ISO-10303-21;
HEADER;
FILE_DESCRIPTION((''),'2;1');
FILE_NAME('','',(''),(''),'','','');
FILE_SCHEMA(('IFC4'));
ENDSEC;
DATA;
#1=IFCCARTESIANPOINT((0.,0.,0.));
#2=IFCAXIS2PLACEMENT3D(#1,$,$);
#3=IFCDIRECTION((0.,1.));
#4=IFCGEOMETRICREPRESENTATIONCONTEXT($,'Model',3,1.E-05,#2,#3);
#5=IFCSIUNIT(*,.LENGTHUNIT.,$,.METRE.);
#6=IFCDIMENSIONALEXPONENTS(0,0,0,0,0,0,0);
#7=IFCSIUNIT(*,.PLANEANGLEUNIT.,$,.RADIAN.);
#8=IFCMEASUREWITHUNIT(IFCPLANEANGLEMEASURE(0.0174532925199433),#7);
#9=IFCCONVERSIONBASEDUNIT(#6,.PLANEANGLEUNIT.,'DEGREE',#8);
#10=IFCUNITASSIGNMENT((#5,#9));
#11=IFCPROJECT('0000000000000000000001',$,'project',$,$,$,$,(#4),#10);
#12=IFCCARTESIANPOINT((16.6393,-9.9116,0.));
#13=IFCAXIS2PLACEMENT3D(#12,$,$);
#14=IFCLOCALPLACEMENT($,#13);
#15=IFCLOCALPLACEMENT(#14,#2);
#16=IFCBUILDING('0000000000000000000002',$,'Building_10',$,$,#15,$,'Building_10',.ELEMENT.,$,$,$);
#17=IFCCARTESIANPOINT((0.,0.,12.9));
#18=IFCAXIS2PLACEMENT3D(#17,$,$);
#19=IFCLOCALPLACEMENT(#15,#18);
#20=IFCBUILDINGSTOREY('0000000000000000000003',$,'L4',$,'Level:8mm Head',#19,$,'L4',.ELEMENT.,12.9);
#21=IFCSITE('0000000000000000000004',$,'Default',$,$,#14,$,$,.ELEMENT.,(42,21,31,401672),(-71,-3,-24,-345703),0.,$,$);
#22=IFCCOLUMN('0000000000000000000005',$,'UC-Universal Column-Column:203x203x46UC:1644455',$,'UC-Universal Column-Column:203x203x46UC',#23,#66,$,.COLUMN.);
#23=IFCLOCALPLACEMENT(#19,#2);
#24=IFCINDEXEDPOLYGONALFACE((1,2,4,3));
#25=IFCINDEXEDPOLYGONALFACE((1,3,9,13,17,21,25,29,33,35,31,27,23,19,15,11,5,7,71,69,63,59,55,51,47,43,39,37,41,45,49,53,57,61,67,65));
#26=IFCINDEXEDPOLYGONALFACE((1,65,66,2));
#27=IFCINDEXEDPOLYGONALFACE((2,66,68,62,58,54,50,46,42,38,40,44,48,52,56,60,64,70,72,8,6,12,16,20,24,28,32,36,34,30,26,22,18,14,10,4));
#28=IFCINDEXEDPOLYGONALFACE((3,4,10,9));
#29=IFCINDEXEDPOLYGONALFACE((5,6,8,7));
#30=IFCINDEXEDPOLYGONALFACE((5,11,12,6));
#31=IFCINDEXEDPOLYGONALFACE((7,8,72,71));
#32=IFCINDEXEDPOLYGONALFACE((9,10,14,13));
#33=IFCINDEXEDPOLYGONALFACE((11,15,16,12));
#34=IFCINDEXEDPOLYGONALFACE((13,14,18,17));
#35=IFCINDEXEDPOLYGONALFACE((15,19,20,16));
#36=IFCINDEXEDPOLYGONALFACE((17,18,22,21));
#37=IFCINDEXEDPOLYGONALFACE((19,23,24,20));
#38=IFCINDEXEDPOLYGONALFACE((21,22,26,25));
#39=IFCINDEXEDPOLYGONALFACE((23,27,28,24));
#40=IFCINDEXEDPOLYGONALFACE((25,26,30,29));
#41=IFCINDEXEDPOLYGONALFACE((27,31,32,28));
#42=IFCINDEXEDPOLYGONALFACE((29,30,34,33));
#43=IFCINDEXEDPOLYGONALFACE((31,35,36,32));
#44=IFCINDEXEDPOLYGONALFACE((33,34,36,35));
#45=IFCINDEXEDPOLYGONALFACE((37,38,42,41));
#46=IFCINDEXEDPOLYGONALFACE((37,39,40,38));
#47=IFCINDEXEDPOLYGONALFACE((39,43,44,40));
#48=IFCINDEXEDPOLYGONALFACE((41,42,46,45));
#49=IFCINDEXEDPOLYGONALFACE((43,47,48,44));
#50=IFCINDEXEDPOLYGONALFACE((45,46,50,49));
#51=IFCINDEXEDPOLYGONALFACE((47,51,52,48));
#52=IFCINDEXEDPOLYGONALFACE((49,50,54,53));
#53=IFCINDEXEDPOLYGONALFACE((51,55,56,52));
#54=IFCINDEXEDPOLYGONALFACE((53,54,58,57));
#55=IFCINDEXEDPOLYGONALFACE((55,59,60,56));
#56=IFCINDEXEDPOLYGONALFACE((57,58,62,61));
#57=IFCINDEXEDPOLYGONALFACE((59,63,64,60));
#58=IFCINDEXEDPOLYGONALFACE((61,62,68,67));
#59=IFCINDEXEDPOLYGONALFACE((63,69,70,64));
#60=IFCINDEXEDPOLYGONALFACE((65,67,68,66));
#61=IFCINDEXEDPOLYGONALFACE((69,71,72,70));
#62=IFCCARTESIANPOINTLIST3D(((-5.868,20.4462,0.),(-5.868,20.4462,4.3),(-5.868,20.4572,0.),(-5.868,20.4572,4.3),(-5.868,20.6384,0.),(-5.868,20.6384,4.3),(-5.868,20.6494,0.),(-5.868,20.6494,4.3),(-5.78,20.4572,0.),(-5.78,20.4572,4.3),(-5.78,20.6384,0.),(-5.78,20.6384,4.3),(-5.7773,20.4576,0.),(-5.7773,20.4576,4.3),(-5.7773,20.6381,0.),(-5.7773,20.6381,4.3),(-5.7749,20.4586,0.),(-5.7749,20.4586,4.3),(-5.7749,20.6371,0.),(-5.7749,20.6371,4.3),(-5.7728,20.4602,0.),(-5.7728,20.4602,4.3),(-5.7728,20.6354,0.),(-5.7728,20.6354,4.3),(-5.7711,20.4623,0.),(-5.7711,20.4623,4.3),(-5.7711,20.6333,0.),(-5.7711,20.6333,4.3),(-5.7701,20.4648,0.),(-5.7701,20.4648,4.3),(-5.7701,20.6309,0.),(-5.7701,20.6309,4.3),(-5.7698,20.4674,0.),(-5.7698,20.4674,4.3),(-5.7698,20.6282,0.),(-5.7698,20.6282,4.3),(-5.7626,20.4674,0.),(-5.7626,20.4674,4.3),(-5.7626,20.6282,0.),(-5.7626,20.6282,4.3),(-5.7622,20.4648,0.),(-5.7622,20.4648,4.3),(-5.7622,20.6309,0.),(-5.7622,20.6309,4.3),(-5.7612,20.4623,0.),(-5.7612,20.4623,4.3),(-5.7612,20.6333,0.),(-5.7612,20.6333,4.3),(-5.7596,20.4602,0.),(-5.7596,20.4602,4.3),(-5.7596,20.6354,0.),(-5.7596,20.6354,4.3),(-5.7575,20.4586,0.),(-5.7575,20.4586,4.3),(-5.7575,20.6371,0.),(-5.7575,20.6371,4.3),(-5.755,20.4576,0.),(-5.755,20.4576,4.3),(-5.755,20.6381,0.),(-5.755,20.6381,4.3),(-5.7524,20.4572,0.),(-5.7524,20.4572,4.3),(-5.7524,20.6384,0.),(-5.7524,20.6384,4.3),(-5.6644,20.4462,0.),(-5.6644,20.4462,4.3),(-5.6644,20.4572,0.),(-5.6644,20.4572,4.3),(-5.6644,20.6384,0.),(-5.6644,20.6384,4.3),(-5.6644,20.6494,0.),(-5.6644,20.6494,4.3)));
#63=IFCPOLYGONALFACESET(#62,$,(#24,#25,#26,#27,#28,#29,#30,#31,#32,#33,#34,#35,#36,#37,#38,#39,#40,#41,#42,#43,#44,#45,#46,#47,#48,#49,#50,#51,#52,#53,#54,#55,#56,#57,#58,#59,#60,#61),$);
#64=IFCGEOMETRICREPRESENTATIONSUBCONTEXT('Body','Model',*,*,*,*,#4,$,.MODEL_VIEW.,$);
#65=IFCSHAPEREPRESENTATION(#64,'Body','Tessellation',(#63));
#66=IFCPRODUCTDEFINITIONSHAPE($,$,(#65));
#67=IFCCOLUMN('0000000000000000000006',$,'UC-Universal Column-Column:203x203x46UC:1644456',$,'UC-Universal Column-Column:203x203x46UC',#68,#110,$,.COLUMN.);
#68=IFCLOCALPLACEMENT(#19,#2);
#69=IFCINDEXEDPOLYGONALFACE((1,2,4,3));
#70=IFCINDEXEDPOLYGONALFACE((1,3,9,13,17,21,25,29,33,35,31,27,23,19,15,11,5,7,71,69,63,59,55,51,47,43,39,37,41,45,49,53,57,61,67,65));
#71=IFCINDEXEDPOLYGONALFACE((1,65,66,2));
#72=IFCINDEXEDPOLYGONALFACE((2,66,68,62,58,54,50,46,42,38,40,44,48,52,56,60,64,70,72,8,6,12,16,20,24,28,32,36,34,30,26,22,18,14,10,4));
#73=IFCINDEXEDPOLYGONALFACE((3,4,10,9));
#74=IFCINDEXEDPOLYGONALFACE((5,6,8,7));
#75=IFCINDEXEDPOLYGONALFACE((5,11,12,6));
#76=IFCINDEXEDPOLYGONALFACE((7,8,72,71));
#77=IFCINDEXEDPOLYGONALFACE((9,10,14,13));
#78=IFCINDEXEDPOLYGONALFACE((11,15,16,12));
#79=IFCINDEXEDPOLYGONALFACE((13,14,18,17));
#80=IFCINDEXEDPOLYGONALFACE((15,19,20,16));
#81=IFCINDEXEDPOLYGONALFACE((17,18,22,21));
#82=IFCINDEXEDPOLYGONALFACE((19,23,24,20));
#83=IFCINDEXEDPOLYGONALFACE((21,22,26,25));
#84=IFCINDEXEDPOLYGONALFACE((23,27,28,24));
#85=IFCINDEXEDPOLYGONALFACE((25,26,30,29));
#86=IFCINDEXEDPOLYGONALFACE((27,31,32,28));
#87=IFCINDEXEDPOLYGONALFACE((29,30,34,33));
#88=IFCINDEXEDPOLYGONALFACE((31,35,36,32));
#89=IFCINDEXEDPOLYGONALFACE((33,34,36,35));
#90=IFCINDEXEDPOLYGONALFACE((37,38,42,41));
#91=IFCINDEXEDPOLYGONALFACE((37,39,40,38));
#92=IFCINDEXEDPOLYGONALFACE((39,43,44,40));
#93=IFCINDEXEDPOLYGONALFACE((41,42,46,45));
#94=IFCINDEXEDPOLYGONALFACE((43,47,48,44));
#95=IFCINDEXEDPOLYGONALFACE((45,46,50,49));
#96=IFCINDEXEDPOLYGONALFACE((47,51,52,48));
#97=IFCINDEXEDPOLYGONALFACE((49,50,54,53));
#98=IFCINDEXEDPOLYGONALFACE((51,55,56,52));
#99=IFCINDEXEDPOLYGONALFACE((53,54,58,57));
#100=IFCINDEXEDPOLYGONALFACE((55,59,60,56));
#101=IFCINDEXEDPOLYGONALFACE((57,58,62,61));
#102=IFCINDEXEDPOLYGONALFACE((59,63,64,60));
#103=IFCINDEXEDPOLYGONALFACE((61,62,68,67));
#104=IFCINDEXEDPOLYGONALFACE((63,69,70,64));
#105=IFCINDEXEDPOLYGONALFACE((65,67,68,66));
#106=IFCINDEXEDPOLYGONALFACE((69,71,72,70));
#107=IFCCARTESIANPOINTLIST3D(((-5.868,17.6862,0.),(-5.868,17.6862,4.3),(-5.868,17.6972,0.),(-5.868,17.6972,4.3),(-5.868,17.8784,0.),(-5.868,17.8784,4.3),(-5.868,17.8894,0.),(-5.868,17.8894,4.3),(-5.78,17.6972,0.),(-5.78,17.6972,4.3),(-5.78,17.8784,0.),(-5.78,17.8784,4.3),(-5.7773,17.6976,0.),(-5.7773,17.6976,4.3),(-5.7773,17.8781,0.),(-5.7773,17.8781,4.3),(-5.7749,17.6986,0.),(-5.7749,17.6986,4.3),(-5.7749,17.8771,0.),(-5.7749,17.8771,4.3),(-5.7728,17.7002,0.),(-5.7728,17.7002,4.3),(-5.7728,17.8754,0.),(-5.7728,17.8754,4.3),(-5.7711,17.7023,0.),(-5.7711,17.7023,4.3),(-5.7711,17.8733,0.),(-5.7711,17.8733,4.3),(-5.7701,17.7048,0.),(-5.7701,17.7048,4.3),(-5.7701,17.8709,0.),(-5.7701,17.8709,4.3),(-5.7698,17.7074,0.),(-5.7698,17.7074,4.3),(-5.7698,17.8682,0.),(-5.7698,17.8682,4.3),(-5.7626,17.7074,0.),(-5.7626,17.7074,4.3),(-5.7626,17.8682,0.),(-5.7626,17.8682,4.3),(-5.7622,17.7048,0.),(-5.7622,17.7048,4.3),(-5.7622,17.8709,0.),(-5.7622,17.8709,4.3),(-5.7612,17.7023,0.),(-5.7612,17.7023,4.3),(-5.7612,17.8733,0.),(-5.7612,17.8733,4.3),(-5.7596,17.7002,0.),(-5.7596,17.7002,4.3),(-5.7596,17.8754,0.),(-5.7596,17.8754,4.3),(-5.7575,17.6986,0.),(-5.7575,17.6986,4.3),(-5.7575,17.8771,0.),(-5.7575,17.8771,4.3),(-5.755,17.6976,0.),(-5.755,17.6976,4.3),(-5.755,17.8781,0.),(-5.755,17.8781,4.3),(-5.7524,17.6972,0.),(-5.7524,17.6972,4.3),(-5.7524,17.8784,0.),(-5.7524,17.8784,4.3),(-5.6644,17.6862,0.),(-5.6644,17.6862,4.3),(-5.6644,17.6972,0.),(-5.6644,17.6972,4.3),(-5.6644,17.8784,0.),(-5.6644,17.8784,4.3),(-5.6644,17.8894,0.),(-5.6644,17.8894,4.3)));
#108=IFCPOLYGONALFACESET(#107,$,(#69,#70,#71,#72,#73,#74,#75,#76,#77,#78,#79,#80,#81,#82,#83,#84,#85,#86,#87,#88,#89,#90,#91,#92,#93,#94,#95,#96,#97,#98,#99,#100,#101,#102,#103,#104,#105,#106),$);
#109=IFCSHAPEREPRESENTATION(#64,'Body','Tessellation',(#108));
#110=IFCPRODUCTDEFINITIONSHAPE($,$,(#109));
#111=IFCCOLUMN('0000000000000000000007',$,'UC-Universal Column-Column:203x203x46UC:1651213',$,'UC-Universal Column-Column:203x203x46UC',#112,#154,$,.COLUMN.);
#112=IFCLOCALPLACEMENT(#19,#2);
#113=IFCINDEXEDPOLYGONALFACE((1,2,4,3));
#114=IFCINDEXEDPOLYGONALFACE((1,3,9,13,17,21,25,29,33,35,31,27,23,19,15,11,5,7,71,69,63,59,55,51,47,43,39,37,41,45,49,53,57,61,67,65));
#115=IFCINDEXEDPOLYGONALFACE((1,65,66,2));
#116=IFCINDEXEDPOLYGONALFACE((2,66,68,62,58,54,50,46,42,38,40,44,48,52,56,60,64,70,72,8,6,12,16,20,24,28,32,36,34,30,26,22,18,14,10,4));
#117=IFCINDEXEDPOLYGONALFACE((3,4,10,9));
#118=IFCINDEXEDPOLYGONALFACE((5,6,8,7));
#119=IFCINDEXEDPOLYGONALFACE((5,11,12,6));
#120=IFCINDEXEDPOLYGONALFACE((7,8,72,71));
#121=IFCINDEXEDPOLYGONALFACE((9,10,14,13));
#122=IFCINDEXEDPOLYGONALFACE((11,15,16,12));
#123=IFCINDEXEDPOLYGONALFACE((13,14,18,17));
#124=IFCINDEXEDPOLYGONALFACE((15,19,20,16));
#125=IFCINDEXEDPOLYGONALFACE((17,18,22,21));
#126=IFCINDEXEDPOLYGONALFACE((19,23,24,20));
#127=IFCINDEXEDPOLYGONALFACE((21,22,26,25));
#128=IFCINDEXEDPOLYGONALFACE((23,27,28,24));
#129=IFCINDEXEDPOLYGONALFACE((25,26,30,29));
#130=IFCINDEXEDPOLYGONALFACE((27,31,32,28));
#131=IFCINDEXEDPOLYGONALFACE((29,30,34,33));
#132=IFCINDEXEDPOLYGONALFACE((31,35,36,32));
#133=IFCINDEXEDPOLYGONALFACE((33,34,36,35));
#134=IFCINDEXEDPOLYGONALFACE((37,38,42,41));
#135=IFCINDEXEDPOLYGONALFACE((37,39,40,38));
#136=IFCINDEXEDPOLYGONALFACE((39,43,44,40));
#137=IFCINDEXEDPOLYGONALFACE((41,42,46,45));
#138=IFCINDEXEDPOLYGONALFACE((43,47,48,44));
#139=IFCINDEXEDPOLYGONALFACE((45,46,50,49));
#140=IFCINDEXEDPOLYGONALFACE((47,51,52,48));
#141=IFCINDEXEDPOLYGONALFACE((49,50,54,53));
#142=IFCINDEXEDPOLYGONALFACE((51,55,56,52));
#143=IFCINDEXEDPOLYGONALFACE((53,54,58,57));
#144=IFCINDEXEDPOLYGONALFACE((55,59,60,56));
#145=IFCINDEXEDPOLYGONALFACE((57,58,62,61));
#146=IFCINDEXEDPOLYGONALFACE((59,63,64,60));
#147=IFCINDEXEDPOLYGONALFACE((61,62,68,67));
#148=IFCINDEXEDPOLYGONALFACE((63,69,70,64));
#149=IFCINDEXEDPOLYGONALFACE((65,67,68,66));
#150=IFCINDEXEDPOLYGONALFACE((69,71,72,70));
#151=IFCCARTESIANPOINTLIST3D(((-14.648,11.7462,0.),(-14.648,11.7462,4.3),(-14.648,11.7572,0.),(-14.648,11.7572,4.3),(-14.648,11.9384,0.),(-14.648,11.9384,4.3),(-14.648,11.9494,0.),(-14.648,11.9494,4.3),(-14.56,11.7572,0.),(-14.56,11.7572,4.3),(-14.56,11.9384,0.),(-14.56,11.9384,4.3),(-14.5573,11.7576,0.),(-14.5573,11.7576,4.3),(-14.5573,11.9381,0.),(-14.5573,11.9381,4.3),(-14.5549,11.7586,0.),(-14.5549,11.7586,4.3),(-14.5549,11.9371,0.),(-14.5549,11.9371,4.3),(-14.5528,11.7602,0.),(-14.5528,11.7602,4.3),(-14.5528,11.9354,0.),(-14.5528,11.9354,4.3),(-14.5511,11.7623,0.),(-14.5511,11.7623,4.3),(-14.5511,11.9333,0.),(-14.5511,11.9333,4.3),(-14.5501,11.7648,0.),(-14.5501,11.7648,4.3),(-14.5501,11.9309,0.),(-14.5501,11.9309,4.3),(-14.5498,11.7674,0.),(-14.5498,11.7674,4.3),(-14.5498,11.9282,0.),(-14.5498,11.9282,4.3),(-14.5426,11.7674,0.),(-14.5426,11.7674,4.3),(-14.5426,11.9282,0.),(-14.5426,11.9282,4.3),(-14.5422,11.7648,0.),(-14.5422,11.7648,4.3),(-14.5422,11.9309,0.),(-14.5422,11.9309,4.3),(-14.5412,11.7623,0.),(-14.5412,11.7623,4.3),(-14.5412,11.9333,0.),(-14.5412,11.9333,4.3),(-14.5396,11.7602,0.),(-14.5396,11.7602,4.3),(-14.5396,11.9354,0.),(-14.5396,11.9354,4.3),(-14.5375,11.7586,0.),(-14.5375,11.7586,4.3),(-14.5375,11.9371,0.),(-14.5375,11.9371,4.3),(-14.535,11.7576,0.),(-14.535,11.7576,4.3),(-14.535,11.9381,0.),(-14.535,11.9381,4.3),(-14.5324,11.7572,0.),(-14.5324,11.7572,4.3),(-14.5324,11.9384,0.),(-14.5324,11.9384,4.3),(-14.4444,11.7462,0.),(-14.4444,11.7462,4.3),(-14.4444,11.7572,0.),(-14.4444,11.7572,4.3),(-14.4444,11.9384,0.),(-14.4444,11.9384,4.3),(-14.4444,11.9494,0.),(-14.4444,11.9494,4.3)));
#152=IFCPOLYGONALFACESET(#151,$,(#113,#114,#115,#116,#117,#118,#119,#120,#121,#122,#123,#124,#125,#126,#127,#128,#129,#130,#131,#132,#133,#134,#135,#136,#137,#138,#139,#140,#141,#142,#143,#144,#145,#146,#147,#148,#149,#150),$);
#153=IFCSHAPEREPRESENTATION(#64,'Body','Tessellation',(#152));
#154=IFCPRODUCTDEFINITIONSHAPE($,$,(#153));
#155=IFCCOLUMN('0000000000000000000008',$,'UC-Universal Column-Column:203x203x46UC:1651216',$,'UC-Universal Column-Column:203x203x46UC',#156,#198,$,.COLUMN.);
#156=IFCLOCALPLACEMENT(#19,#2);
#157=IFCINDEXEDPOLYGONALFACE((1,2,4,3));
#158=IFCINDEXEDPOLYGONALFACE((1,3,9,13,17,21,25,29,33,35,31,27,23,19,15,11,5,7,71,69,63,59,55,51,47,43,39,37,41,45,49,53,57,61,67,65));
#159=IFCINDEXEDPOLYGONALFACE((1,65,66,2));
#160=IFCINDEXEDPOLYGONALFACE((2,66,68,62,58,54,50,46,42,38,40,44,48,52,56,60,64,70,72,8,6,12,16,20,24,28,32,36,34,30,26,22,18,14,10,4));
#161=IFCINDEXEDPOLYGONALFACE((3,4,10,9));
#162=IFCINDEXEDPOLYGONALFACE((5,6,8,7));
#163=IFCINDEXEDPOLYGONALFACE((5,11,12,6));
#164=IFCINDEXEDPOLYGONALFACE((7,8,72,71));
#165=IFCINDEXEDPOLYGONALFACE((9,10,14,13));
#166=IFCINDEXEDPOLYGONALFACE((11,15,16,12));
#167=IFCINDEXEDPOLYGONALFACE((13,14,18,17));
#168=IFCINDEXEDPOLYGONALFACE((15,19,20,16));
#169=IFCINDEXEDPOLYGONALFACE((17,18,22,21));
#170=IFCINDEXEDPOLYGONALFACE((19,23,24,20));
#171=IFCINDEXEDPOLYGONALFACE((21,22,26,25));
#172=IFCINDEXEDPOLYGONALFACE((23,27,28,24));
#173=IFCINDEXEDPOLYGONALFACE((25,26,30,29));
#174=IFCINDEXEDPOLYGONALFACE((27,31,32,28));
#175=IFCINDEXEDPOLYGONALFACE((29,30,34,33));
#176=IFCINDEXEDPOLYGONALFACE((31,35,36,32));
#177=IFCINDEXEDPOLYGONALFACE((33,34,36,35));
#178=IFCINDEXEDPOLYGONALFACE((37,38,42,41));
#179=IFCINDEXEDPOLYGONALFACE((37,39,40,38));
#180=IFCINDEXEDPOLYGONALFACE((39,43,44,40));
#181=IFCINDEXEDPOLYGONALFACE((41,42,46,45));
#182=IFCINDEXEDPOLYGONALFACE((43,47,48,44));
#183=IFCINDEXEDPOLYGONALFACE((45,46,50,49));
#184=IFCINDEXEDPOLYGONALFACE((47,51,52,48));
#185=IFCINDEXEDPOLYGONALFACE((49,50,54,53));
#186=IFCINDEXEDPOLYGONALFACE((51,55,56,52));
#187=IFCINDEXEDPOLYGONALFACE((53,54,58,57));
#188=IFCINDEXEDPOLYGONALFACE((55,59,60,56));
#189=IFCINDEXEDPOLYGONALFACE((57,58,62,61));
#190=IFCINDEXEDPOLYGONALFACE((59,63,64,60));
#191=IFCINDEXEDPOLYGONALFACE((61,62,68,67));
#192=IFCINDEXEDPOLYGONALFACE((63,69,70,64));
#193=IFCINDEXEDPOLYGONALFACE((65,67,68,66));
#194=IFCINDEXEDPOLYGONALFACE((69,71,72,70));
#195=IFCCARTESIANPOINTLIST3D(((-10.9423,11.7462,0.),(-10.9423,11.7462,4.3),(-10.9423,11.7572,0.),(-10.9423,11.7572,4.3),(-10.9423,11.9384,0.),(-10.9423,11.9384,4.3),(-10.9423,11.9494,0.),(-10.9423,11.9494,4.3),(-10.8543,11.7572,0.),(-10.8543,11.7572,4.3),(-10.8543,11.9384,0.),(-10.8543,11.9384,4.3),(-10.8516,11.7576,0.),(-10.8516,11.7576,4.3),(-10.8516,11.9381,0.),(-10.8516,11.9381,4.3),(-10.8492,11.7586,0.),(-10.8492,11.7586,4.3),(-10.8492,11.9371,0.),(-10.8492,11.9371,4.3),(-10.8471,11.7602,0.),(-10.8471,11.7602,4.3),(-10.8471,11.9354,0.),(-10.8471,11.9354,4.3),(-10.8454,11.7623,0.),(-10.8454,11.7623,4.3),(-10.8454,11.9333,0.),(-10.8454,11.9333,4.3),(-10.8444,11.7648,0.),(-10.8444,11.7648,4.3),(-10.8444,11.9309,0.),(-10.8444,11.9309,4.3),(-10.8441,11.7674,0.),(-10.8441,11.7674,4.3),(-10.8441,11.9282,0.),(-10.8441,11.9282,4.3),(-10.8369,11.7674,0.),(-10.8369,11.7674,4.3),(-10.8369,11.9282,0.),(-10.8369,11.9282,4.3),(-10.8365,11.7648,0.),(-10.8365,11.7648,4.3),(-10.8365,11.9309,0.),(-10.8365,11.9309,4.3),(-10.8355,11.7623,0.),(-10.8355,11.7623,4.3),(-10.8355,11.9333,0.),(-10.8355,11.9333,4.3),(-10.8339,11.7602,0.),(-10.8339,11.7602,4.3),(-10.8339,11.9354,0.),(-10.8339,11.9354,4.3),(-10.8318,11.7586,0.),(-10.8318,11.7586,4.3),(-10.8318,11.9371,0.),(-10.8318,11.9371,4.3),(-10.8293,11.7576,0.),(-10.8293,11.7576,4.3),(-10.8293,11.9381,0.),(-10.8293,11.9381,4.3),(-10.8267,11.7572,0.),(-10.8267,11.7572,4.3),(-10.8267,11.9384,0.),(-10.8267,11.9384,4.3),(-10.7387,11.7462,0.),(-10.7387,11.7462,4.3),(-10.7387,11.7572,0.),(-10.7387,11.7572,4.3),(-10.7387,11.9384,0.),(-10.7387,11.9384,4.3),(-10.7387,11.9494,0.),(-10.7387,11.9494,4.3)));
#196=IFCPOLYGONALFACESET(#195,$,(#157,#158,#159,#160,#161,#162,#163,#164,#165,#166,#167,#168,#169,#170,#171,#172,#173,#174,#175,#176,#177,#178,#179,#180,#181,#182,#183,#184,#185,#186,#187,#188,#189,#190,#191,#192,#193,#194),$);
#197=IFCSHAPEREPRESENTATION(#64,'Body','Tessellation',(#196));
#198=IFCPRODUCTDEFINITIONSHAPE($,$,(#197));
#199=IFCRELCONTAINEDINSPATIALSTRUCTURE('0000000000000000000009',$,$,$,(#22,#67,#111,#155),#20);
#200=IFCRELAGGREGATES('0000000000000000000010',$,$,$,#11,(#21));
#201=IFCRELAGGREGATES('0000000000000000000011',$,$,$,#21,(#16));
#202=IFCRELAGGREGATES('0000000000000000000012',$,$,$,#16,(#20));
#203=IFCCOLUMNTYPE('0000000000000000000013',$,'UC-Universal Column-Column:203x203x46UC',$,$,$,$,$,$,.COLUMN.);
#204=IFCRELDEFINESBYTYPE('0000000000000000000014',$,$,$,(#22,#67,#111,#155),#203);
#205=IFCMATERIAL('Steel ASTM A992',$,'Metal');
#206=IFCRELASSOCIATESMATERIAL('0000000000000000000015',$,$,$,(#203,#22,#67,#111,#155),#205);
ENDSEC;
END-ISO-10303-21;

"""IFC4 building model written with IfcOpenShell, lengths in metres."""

from ifc_helpers import new_model, entity, si_unit, converted_unit, direction, frame, origin, place, context, subcontext, project, spatial, line, arc, indexed_curve, outline, extrude, source, transform, mapped, material, type_object, type_shapes, element, save


model = new_model("IFC4")

# Units and contexts
model_context = context("Model", 3, precision=1e-05, world=origin(), true_north=direction((0.0, 1.0)))
body_context = subcontext(model_context, "Body", "Model", "MODEL_VIEW")
ifc_project = project(units=[si_unit("LENGTHUNIT", "METRE"), converted_unit("PLANEANGLEUNIT", "DEGREE", entity("IfcPlaneAngleMeasure", 0.0174532925199433), si_unit("PLANEANGLEUNIT", "RADIAN"), dimensions=[0, 0, 0, 0, 0, 0, 0])], contexts=[model_context])

# Site, building, storey
site_placement = place(None, frame((16.6393, -9.9116, 0.0)))
site = spatial("IfcSite", under=ifc_project, at=site_placement, Name="Default", CompositionType="ELEMENT", RefLatitude=(42, 21, 31, 401672), RefLongitude=(-71, -3, -24, -345703), RefElevation=0.0)
building_placement = place(site_placement, origin())
building = spatial("IfcBuilding", under=site, at=building_placement, Name="Building_10", LongName="Building_10", CompositionType="ELEMENT")
storey_placement = place(building_placement, frame((0.0, 0.0, 12.9)))
storey = spatial("IfcBuildingStorey", under=building, at=storey_placement, Name="L4", ObjectType="Level:8mm Head", LongName="L4", CompositionType="ELEMENT", Elevation=12.9)

# Columns
ifc_material_1 = material(Name="Steel ASTM A992", Category="Metal")
column_type = type_object("IfcColumnType", Name="UC-Universal Column-Column:203x203x46UC", PredefinedType="COLUMN", material=ifc_material_1)
shared_shape_1 = source(origin(), body_context, "Body", "SweptSolid", [
    extrude(outline(indexed_curve([(-0.1018, -0.1016), (0.1018, -0.1016), (0.1018, -0.0906), (0.0138, -0.0906), (0.0066, -0.0876), (0.0036, -0.0804), (0.0036, 0.0804), (0.0066, 0.0876), (0.0138, 0.0906), (0.1018, 0.0906), (0.1018, 0.1016), (-0.1018, 0.1016), (-0.1018, 0.0906), (-0.0138, 0.0906), (-0.0066, 0.0876), (-0.0036, 0.0804), (-0.0036, -0.0804), (-0.0066, -0.0876), (-0.0138, -0.0906), (-0.1018, -0.0906)], segments=[line(1, 2, 3, 4), arc(4, 5, 6), line(6, 7), arc(7, 8, 9), line(9, 10, 11, 12, 13, 14), arc(14, 15, 16), line(16, 17), arc(17, 18, 19), line(19, 20, 1)], self_intersect=False)), frame((0.0, 0.0, 12.9), z_axis=(0.0, 0.0, 1.0), x_axis=(-1.0, 0.0, 0.0)), (0.0, 0.0, 1.0), 4.3),
])
type_shapes(column_type, [shared_shape_1])
for number, where, name in (
    (1, (-5.7662, 20.5478, -12.9), "UC-Universal Column-Column:203x203x46UC:1644455"),
    (2, (-5.7662, 17.7878, -12.9), "UC-Universal Column-Column:203x203x46UC:1644456"),
    (3, (-14.5462, 11.8478, -12.9), "UC-Universal Column-Column:203x203x46UC:1651213"),
    (4, (-10.8405, 11.8478, -12.9), "UC-Universal Column-Column:203x203x46UC:1651216"),
):
    element("IfcColumn", number, at=place(storey_placement, frame(where)), inside=storey, type_object=column_type, material=ifc_material_1, Name=name, ObjectType="UC-Universal Column-Column:203x203x46UC", PredefinedType="COLUMN", context=body_context, shape_type="MappedRepresentation", body=[
        mapped(shared_shape_1, transform((0.0, 0.0, 0.0), scale=1.0)),
    ])

save(model, "model.ifc")
